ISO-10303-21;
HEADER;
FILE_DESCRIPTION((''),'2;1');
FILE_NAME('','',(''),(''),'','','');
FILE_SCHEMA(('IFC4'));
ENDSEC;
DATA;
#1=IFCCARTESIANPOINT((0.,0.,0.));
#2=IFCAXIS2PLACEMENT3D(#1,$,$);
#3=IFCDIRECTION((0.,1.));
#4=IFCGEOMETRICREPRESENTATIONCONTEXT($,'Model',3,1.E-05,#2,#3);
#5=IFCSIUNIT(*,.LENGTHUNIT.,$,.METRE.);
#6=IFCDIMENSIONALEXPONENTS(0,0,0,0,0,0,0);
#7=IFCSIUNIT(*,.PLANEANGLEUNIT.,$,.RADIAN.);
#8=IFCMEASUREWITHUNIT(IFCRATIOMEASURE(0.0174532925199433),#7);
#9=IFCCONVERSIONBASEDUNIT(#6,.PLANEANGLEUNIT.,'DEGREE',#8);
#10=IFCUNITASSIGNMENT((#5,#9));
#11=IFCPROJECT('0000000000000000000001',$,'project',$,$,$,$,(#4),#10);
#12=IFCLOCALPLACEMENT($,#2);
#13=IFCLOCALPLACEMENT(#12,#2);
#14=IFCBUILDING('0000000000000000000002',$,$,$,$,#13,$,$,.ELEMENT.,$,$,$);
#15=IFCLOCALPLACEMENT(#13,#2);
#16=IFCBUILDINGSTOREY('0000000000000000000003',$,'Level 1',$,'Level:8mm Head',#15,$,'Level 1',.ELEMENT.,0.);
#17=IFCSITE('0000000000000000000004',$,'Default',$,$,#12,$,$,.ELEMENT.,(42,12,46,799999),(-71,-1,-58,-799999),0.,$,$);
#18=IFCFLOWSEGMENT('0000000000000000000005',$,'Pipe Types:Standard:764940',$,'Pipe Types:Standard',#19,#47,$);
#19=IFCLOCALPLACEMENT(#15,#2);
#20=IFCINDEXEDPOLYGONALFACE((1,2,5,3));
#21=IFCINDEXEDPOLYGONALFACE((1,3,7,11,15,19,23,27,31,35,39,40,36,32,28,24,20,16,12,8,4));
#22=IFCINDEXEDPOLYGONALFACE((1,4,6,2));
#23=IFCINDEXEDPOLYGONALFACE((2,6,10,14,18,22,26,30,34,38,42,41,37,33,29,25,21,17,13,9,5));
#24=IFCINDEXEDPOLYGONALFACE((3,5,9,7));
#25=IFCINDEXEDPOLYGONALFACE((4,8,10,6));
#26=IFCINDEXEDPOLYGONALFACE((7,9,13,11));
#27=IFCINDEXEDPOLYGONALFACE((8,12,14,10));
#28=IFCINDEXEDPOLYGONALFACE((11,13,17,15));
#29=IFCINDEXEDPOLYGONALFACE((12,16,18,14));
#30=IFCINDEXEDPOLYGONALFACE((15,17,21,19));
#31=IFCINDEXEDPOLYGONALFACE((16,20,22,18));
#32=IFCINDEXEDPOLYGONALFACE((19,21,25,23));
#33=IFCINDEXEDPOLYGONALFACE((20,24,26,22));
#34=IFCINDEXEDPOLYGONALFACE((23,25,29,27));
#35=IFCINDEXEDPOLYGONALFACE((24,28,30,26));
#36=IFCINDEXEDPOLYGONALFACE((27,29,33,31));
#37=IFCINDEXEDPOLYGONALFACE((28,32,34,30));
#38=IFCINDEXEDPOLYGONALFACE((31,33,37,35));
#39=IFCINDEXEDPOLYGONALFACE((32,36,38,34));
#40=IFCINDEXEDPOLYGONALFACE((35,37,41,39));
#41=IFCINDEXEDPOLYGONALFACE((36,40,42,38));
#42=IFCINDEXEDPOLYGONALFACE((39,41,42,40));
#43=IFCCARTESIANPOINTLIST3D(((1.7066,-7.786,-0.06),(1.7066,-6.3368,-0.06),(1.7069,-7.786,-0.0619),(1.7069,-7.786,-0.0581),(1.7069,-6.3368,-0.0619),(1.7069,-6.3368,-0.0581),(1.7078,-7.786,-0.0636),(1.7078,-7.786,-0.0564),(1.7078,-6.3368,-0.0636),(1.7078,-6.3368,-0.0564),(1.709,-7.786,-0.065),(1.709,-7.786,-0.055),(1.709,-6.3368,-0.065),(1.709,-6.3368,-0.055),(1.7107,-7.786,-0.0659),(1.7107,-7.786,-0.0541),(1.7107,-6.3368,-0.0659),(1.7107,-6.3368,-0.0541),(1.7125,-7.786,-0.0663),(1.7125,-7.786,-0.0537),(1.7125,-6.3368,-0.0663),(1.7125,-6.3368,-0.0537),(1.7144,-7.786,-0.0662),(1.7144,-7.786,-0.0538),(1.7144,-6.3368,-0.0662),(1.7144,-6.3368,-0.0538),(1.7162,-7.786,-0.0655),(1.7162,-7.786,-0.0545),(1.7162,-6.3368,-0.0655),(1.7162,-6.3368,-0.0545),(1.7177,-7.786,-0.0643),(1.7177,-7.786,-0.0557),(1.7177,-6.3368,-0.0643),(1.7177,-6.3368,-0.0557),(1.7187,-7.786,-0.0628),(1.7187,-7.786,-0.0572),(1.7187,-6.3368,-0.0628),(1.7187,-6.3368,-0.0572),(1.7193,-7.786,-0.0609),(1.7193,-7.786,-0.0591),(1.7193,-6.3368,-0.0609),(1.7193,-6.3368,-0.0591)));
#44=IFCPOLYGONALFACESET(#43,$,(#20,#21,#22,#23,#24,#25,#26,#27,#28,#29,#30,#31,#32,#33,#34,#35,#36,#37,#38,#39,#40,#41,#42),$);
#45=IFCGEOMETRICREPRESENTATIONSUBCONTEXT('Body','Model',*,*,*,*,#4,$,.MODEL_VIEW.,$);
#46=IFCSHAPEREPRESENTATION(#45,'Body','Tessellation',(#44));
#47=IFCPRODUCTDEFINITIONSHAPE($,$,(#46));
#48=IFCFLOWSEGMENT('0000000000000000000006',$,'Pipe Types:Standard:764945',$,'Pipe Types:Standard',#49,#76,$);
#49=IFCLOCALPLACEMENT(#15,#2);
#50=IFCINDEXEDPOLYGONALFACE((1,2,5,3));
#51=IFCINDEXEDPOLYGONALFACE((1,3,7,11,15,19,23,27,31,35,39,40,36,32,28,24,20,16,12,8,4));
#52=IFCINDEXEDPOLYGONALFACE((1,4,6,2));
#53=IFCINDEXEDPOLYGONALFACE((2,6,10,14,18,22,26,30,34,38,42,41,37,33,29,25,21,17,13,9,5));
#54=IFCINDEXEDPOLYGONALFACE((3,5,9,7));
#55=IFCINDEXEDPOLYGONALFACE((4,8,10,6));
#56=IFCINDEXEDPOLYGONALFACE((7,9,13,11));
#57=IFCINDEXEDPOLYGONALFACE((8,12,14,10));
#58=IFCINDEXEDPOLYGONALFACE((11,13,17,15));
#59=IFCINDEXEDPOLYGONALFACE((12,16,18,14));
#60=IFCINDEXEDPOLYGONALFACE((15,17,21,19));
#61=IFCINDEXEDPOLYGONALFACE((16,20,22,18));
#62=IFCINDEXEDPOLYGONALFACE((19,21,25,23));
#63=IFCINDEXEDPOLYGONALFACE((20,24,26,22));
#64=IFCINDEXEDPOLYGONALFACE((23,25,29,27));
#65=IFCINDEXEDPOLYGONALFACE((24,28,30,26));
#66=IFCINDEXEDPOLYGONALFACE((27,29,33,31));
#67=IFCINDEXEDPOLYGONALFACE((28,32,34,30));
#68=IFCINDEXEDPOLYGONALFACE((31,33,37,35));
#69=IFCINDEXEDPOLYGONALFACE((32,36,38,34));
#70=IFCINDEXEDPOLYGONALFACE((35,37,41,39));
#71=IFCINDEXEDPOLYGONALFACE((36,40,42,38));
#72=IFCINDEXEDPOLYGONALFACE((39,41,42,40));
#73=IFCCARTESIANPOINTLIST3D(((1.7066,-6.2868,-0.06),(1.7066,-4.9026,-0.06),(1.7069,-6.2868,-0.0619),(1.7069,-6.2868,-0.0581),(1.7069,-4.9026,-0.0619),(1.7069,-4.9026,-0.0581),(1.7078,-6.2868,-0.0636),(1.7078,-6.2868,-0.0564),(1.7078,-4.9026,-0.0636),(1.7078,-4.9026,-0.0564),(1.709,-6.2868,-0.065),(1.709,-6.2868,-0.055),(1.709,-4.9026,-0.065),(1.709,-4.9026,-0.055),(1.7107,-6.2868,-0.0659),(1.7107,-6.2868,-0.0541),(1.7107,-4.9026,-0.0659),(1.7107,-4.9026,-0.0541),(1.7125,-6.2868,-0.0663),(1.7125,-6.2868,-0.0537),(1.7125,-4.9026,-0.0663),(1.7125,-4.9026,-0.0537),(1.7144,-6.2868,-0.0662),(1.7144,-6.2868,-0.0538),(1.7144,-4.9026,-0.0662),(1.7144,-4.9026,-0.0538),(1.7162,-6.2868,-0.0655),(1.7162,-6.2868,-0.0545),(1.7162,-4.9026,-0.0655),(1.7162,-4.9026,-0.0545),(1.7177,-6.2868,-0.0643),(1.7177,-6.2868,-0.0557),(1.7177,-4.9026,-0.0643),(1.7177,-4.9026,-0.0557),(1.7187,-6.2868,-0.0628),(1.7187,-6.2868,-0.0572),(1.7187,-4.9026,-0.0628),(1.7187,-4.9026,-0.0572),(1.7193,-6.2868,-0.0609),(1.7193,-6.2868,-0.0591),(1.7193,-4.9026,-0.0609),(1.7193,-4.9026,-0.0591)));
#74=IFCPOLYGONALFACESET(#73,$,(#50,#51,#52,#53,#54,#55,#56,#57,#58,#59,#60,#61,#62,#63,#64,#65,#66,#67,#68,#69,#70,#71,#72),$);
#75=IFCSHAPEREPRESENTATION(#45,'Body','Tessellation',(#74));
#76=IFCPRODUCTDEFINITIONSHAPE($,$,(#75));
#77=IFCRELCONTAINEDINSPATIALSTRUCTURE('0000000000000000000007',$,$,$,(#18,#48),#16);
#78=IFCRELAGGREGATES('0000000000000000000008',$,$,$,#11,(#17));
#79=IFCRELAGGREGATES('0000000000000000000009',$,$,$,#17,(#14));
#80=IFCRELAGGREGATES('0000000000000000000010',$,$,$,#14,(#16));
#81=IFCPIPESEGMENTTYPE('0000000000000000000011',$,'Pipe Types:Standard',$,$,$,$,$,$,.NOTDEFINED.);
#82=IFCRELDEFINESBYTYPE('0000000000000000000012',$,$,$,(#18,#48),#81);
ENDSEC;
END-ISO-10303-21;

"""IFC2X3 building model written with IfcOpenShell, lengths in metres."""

from ifc_helpers import new_model, entity, si_unit, converted_unit, direction, frame, frame_2d, origin, place, context, subcontext, project, spatial, circle, extrude, type_object, element, save


model = new_model("IFC2X3")

# Units and contexts
model_context = context("Model", 3, precision=1e-05, world=origin(), true_north=direction((0.0, 1.0)))
body_context = subcontext(model_context, "Body", "Model", "MODEL_VIEW")
ifc_project = project(units=[si_unit("LENGTHUNIT", "METRE"), converted_unit("PLANEANGLEUNIT", "DEGREE", entity("IfcRatioMeasure", 0.0174532925199433), si_unit("PLANEANGLEUNIT", "RADIAN"), dimensions=[0, 0, 0, 0, 0, 0, 0])], contexts=[model_context])

# Site, building, storey
site_placement = place(None, origin())
site = spatial("IfcSite", under=ifc_project, at=site_placement, Name="Default", CompositionType="ELEMENT", RefLatitude=(42, 12, 46, 799999), RefLongitude=(-71, -1, -58, -799999), RefElevation=0.0)
building_placement = place(site_placement, origin())
building = spatial("IfcBuilding", under=site, at=building_placement, CompositionType="ELEMENT")
storey_placement = place(building_placement, origin())
storey = spatial("IfcBuildingStorey", under=building, at=storey_placement, Name="Level 1", ObjectType="Level:8mm Head", LongName="Level 1", CompositionType="ELEMENT", Elevation=0.0)

# Flow segments
pipe_segment_type = type_object("IfcPipeSegmentType", Name="Pipe Types:Standard", PredefinedType="NOTDEFINED")
flow_segment_1_placement = place(storey_placement, origin())
element("IfcFlowSegment", 1, at=flow_segment_1_placement, inside=storey, type_object=pipe_segment_type, Name="Pipe Types:Standard:764940", ObjectType="Pipe Types:Standard", context=body_context, shape_type="SweptSolid", body=[
    extrude(circle(Radius=0.0063, at=frame_2d((0.0, 0.0), x_axis=(1.0, 0.0))), frame((1.713, -7.786, -0.06), z_axis=(0.0, 1.0, 0.0), x_axis=(-1.0, 0.0, 0.0)), (0.0, 0.0, 1.0), 1.4492),
])
flow_segment_2_placement = place(storey_placement, origin())
element("IfcFlowSegment", 2, at=flow_segment_2_placement, inside=storey, type_object=pipe_segment_type, Name="Pipe Types:Standard:764945", ObjectType="Pipe Types:Standard", context=body_context, shape_type="SweptSolid", body=[
    extrude(circle(Radius=0.0063, at=frame_2d((0.0, 0.0), x_axis=(1.0, 0.0))), frame((1.713, -6.2868, -0.06), z_axis=(0.0, 1.0, 0.0), x_axis=(-1.0, 0.0, 0.0)), (0.0, 0.0, 1.0), 1.3842),
])

save(model, "model.ifc")
